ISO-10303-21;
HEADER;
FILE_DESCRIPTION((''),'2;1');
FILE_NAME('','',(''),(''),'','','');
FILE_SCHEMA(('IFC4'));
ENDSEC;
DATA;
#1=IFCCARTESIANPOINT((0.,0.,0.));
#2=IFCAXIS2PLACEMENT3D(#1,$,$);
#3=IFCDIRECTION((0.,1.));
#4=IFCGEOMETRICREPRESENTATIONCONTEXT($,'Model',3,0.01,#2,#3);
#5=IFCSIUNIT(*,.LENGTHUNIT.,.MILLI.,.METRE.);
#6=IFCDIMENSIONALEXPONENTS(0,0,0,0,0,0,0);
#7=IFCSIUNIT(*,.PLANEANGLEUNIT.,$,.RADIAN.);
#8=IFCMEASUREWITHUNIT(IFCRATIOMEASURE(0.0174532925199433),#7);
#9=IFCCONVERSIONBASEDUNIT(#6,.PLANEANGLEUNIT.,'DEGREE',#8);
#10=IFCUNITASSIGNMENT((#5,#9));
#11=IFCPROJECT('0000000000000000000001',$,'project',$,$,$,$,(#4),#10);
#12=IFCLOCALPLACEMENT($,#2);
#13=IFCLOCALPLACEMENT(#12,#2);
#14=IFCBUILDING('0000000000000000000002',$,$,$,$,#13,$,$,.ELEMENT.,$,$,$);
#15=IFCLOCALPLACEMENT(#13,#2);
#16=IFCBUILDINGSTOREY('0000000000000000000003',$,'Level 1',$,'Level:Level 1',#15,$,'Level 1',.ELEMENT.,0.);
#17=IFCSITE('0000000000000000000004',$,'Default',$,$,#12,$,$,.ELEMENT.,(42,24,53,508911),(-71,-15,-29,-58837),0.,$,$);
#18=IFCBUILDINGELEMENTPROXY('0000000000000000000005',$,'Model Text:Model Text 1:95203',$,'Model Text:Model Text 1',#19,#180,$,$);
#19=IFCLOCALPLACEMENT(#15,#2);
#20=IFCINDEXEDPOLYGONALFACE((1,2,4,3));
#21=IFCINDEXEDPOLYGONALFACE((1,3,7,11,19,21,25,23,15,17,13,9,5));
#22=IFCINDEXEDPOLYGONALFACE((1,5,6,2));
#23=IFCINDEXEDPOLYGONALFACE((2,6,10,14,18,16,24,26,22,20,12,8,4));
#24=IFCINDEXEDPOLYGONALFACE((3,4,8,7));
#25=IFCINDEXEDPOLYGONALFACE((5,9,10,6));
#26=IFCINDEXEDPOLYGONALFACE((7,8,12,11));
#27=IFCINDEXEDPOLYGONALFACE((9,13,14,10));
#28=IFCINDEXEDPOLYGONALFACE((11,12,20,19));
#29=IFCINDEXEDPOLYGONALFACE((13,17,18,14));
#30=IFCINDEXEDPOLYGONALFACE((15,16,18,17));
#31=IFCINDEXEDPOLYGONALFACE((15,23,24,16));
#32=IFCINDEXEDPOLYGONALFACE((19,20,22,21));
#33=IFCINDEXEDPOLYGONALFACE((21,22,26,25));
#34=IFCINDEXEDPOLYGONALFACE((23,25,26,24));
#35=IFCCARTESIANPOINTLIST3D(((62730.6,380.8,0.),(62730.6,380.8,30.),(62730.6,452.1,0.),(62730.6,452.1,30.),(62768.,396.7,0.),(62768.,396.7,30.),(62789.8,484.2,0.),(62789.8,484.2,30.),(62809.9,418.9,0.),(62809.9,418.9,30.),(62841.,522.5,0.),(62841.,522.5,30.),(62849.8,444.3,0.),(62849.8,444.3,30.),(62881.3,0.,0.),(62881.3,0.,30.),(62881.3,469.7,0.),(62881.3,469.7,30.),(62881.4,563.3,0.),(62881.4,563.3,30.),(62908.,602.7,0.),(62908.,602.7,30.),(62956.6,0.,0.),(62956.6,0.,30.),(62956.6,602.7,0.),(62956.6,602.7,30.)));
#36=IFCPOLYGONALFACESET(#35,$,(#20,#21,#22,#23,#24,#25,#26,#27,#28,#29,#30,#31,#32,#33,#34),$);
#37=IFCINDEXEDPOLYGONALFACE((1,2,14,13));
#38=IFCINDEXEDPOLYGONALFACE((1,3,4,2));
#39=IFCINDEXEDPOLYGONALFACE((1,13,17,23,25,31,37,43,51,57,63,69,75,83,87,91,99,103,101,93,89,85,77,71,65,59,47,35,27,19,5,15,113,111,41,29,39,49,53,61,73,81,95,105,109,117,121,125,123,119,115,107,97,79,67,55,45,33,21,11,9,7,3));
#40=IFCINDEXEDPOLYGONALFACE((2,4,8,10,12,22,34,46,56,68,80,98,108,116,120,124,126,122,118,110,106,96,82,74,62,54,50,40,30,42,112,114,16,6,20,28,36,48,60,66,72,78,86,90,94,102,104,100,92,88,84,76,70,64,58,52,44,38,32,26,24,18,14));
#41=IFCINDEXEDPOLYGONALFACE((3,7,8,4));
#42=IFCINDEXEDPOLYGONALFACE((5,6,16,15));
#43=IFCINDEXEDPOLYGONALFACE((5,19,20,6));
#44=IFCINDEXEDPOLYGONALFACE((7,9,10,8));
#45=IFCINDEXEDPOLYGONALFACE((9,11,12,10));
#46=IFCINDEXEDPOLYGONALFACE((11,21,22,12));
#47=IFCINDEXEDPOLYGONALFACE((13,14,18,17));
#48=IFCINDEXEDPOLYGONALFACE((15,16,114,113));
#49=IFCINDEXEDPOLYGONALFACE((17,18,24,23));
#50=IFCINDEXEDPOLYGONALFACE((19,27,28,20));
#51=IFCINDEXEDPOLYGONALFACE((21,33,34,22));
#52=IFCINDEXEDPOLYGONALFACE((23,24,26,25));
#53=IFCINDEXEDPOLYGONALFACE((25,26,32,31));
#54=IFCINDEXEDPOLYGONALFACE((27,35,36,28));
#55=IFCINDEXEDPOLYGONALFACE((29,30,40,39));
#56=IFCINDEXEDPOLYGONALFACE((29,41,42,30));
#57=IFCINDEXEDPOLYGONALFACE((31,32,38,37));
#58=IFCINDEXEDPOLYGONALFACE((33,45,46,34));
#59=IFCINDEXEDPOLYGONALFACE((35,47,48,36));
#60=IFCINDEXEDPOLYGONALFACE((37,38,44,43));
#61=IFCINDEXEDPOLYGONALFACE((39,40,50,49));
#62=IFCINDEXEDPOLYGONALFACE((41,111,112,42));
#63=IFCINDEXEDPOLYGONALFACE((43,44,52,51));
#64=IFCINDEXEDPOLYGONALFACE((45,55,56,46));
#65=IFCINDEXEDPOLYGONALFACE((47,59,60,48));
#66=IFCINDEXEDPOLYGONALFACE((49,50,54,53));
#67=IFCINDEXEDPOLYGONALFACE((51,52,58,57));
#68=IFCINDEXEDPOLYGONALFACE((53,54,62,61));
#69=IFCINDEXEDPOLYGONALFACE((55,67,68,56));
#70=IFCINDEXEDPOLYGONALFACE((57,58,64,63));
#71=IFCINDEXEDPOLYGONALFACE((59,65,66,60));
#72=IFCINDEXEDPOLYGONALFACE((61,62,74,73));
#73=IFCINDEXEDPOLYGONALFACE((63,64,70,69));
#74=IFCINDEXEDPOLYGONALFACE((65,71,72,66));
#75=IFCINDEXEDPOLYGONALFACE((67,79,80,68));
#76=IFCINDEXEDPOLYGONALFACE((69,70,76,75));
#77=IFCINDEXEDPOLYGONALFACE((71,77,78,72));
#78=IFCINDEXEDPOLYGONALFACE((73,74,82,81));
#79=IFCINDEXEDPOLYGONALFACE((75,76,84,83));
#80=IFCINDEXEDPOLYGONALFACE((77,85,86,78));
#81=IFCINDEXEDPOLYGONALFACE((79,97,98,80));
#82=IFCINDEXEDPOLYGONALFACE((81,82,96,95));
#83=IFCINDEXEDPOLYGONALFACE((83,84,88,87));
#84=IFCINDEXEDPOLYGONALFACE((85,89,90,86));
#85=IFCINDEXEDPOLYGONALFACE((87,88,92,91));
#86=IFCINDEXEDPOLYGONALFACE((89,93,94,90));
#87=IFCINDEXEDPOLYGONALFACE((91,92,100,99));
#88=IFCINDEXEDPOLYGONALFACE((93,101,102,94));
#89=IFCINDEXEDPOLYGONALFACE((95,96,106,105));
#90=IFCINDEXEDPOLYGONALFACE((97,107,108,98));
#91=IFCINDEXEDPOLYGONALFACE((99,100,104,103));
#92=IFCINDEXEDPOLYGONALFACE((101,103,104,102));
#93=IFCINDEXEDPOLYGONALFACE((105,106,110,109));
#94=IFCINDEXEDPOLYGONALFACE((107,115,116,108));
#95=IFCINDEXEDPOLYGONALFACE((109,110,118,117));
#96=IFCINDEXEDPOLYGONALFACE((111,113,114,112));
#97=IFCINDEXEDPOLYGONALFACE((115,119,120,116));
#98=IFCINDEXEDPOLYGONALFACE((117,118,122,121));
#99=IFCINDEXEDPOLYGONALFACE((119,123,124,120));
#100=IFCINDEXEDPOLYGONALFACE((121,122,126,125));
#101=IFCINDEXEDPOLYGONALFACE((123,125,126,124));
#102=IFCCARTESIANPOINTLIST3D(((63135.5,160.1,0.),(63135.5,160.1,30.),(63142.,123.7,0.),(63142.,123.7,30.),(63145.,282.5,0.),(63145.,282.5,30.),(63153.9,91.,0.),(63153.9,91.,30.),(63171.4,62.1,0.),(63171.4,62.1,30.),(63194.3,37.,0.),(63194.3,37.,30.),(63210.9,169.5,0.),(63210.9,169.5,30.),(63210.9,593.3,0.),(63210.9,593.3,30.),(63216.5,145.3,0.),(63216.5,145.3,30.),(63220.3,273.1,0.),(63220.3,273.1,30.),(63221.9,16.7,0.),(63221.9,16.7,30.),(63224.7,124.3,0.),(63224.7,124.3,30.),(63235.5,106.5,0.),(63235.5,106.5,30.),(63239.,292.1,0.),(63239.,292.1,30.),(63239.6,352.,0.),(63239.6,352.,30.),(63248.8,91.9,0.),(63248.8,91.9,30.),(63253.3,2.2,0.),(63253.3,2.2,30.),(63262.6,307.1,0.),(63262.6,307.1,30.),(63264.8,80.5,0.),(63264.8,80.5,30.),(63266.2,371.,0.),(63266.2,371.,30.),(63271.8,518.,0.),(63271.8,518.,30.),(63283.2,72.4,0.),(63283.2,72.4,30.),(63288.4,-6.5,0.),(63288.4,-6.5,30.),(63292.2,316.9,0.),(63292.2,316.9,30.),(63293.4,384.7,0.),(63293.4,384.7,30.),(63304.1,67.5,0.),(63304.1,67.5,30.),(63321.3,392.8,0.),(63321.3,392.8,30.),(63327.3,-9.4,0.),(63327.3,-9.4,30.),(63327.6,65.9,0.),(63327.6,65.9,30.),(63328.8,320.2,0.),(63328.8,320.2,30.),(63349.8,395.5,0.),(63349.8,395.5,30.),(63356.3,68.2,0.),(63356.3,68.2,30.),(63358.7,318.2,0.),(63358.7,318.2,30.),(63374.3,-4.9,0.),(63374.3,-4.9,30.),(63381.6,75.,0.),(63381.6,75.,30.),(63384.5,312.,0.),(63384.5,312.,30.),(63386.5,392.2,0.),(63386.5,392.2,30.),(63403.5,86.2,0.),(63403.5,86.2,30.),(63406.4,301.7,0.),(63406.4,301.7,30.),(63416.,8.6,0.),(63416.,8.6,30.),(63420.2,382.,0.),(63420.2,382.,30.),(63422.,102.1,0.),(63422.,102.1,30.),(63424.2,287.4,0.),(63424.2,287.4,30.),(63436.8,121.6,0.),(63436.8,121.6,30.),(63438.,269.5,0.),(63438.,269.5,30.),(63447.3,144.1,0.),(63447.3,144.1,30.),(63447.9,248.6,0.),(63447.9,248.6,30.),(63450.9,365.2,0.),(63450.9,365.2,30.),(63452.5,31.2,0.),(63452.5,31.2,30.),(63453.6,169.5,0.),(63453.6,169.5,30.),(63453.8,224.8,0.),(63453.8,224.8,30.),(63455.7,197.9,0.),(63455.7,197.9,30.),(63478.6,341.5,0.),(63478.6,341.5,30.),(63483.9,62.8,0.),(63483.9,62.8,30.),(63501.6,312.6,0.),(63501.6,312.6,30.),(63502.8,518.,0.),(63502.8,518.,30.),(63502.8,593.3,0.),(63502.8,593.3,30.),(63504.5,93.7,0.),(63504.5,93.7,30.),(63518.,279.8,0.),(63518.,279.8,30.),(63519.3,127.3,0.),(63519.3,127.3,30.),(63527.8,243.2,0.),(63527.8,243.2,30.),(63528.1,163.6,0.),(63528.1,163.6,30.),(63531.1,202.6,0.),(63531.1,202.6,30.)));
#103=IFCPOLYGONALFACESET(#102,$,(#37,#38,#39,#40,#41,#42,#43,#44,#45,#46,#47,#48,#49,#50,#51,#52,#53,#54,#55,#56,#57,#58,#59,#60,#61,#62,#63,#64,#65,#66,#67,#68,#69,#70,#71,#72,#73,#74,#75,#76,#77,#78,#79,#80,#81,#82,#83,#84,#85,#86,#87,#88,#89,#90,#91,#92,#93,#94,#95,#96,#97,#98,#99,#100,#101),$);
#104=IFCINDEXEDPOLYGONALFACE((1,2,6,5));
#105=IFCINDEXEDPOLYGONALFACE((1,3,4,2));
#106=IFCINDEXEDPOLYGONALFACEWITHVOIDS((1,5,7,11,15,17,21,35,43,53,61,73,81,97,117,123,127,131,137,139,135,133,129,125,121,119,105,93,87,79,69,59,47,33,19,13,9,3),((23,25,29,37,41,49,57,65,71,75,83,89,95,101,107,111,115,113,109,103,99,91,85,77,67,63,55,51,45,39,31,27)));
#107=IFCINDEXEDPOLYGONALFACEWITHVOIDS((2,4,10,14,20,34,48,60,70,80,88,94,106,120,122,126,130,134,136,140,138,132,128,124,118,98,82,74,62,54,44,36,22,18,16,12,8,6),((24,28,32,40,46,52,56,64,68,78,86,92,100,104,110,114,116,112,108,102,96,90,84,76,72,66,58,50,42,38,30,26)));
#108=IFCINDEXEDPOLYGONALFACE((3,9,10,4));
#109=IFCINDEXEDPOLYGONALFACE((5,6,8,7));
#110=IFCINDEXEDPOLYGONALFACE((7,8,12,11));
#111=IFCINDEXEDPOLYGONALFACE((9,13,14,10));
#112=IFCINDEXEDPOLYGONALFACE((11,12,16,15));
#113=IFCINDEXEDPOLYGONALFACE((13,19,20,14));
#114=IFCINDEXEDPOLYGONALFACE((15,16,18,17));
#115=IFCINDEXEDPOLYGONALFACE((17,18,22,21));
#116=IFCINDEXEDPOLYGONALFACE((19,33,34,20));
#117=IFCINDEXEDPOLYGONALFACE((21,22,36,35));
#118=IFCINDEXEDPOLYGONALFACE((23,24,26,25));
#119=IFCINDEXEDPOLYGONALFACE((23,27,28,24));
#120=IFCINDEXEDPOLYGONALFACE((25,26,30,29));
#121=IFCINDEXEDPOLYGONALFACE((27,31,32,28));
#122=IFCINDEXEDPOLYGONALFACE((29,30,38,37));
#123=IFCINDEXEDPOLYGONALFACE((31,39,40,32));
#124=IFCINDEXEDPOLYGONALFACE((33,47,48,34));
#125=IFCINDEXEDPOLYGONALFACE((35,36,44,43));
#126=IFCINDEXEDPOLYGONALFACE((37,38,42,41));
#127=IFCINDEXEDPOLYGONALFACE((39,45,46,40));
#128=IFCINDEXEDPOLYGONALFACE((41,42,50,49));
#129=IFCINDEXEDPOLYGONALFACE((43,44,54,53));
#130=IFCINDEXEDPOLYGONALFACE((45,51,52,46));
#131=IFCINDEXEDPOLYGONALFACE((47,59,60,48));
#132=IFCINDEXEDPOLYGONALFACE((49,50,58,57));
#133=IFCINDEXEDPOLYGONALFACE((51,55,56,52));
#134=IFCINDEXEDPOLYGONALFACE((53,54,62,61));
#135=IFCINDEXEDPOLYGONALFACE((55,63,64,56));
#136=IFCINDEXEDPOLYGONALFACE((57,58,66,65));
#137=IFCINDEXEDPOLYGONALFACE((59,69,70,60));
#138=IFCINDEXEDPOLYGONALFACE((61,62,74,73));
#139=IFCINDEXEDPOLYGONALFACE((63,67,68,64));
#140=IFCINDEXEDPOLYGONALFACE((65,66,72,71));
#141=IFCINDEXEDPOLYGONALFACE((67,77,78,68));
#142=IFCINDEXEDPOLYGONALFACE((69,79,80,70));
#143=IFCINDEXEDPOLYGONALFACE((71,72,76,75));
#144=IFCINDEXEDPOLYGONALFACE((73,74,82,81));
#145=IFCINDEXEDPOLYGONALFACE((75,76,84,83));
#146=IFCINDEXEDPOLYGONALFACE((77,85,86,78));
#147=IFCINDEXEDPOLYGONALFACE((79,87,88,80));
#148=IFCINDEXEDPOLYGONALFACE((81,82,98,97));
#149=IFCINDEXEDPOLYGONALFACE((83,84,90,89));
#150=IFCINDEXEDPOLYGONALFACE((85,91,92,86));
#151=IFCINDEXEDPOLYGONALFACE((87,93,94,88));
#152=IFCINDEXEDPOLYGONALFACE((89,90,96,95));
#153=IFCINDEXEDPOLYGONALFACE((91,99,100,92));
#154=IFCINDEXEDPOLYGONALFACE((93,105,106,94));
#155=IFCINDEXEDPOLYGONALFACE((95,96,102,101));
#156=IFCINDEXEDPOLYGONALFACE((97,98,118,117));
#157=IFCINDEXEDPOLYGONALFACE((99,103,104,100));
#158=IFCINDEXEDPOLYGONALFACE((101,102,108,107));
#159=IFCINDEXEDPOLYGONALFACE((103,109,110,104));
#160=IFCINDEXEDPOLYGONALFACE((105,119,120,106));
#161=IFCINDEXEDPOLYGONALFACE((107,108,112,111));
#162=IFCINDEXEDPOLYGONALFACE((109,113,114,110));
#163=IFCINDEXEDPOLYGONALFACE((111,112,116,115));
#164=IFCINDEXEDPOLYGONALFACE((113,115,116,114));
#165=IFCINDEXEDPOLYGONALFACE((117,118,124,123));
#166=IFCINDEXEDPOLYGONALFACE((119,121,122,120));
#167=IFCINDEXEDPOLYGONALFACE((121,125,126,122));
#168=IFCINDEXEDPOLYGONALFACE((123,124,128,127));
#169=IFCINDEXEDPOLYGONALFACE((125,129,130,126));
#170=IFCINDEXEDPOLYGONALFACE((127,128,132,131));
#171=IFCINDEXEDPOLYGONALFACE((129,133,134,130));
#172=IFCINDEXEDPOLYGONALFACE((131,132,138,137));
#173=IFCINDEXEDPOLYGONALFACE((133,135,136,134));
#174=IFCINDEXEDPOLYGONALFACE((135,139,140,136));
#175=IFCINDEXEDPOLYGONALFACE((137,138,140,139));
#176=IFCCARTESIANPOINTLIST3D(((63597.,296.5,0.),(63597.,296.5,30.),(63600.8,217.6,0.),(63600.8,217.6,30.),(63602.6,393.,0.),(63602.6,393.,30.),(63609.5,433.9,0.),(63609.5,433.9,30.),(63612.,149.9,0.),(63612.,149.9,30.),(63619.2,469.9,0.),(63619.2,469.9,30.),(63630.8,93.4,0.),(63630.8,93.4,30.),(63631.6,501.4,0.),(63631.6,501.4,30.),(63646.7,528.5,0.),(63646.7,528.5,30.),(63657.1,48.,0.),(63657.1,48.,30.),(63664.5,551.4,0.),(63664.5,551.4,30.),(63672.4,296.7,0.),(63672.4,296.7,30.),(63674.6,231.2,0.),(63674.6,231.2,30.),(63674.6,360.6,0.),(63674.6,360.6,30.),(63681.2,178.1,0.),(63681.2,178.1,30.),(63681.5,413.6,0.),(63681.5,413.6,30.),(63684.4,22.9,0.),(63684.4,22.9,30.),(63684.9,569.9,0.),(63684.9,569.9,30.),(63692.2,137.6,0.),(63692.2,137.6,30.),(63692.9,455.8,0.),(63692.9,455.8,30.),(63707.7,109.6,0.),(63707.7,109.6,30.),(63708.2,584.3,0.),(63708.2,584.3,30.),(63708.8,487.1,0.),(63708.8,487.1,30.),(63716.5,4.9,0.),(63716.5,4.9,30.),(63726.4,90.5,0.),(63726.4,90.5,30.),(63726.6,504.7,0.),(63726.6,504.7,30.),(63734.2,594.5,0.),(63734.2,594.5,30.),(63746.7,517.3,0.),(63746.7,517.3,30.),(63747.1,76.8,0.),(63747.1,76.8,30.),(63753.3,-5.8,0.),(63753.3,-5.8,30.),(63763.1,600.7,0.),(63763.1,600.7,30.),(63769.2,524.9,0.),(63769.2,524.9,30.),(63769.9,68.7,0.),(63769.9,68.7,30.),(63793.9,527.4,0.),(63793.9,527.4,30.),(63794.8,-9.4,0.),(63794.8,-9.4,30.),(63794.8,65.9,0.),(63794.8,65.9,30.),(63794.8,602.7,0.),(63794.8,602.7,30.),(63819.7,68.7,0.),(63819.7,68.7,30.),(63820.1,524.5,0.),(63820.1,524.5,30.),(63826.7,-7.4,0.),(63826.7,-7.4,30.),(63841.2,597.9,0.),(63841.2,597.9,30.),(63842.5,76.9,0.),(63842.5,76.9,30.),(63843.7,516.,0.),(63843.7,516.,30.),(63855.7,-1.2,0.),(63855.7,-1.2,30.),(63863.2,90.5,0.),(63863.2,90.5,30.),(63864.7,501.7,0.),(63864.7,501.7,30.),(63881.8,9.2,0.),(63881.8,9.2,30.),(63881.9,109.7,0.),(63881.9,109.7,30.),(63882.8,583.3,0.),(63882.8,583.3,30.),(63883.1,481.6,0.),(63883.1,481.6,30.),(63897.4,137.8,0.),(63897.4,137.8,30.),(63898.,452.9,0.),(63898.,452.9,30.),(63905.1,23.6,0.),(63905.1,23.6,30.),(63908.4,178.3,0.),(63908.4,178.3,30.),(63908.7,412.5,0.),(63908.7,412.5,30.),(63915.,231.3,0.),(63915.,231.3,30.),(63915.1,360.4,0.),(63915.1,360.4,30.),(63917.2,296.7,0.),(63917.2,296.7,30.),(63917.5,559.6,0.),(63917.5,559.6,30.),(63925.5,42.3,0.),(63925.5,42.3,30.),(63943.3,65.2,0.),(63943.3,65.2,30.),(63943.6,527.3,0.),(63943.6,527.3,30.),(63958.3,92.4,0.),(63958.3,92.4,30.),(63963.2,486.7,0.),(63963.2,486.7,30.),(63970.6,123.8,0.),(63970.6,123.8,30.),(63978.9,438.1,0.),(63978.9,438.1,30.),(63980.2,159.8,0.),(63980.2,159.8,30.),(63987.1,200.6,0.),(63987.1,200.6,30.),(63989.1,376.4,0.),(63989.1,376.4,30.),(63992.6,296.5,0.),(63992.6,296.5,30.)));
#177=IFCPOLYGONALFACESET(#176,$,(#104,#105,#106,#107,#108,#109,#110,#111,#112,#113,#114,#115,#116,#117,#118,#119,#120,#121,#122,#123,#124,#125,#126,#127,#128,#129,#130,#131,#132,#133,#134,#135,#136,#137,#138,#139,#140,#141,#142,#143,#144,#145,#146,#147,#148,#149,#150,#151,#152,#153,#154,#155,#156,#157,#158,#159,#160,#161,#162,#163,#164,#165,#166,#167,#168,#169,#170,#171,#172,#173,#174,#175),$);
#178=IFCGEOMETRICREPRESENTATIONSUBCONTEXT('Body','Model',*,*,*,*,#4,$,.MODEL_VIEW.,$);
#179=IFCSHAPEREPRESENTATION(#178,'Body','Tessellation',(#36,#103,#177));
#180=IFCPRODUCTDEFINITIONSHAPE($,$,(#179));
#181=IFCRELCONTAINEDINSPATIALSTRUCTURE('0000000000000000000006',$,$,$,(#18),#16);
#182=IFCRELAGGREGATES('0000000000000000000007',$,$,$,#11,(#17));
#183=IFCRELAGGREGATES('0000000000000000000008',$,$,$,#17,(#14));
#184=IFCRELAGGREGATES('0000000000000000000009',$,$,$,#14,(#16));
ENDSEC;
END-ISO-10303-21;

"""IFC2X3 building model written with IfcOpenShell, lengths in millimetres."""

from ifc_helpers import new_model, entity, si_unit, converted_unit, direction, frame, origin, place, context, subcontext, project, spatial, polyline, outline, extrude, element, save


model = new_model("IFC2X3")

# Units and contexts
model_context = context("Model", 3, precision=0.01, world=origin(), true_north=direction((0.0, 1.0)))
body_context = subcontext(model_context, "Body", "Model", "MODEL_VIEW")
ifc_project = project(units=[si_unit("LENGTHUNIT", "METRE", prefix="MILLI"), converted_unit("PLANEANGLEUNIT", "DEGREE", entity("IfcRatioMeasure", 0.0174532925199433), si_unit("PLANEANGLEUNIT", "RADIAN"), dimensions=[0, 0, 0, 0, 0, 0, 0])], contexts=[model_context])

# Site, building, storey
site_placement = place(None, origin())
site = spatial("IfcSite", under=ifc_project, at=site_placement, Name="Default", CompositionType="ELEMENT", RefLatitude=(42, 24, 53, 508911), RefLongitude=(-71, -15, -29, -58837), RefElevation=0.0)
building_placement = place(site_placement, origin())
building = spatial("IfcBuilding", under=site, at=building_placement, CompositionType="ELEMENT")
storey_placement = place(building_placement, origin())
storey = spatial("IfcBuildingStorey", under=building, at=storey_placement, Name="Level 1", ObjectType="Level:Level 1", LongName="Level 1", CompositionType="ELEMENT", Elevation=0.0)

# Building element proxy
proxy_1_placement = place(storey_placement, origin())
element("IfcBuildingElementProxy", 1, at=proxy_1_placement, inside=storey, Name="Model Text:Model Text 1:95203", ObjectType="Model Text:Model Text 1", context=body_context, shape_type="SweptSolid", body=[
    extrude(outline(polyline([(-410.6, -111.6), (192.1, -111.6), (192.1, -63.1), (152.7, -36.4), (111.9, 4.0), (73.6, 55.2), (41.4, 114.4), (-29.8, 114.4), (-13.9, 77.0), (8.3, 35.1), (33.7, -4.8), (59.1, -36.3), (-410.6, -36.3), (-410.6, -111.6)])), frame((62845.0, 410.6, 0.0), z_axis=(0.0, 0.0, 1.0), x_axis=(0.0, 1.0, 0.0)), (0.0, 0.0, 1.0), 30.0),
    extrude(outline(polyline([(12.1, -219.3), (49.1, -219.3), (83.4, -213.2), (114.8, -201.1), (143.5, -182.8), (168.3, -159.2), (188.1, -130.8), (202.8, -97.8), (212.4, -60.0), (216.1, -12.9), (210.0, 30.5), (194.1, 70.4), (168.4, 106.8), (141.6, 132.5), (111.1, 152.9), (76.9, 167.9), (39.0, 177.6), (-1.5, 181.4), (-39.3, 178.1), (-74.4, 167.6), (-106.9, 150.1), (-135.0, 126.9), (-157.0, 99.6), (-172.8, 68.1), (-182.5, 32.6), (-184.8, 4.0), (-181.6, -24.8), (-172.9, -54.0), (-158.8, -83.5), (-316.6, -22.9), (-276.5, 204.6), (-350.7, 217.7), (-401.4, -69.8), (-106.8, -188.8), (-84.5, -116.2), (-99.9, -94.5), (-110.6, -68.6), (-115.1, -37.8), (-112.0, -1.2), (-104.8, 27.9), (-94.2, 52.3), (-80.3, 72.0), (-63.1, 87.0), (-43.0, 97.5), (-20.8, 103.6), (3.8, 105.3), (30.5, 102.6), (58.1, 95.6), (82.1, 84.9), (102.4, 70.6), (119.1, 52.7), (131.4, 31.7), (138.7, 8.2), (141.0, -17.9), (138.2, -46.6), (132.6, -69.4), (124.1, -89.2), (112.9, -105.9), (99.0, -119.6), (82.3, -130.2), (62.9, -137.7), (40.8, -142.2), (15.9, -143.5), (12.1, -219.3)])), frame((63349.4, 210.2, 0.0), z_axis=(0.0, 0.0, 1.0), x_axis=(0.173842, -0.984774, 0.0)), (0.0, 0.0, 1.0), 30.0),
    extrude(outline(polyline([(-10.6, -198.7), (68.3, -198.7), (136.5, -190.7), (193.9, -174.7), (240.5, -150.6), (266.9, -124.4), (286.3, -93.2), (298.8, -57.0), (304.3, -15.7), (303.8, 16.2), (299.0, 45.5), (289.9, 72.1), (276.6, 96.0), (258.9, 117.3), (236.9, 136.2), (210.4, 152.5), (179.6, 166.3), (144.1, 177.6), (103.7, 186.3), (8.2, 196.4), (-71.8, 196.7), (-134.0, 189.4), (-183.3, 176.1), (-224.7, 158.4), (-258.2, 133.9), (-283.5, 100.3), (-300.1, 59.5), (-307.1, 13.4), (-306.6, -18.4), (-301.8, -47.5), (-292.8, -74.0), (-279.6, -97.9), (-262.0, -119.2), (-240.0, -138.1), (-213.6, -154.5), (-182.8, -168.4), (-147.3, -179.8), (-106.7, -188.6), (-10.6, -198.7)]), holes=[polyline([(-7.2, -123.5), (-71.0, -118.2), (-123.6, -108.8), (-165.2, -95.4), (-195.7, -78.0), (-212.4, -59.4), (-224.1, -38.7), (-230.6, -15.9), (-231.9, 8.9), (-227.8, 35.0), (-218.1, 58.1), (-202.8, 78.4), (-182.0, 95.8), (-152.6, 109.4), (-111.7, 118.1), (-59.4, 122.0), (4.4, 121.1), (69.6, 115.8), (122.2, 106.7), (162.2, 93.7), (189.5, 77.0), (207.7, 57.4), (220.4, 36.0), (227.5, 12.8), (229.1, -12.1), (225.2, -36.8), (215.9, -59.2), (201.3, -79.3), (181.4, -97.1), (152.6, -111.2), (111.6, -120.3), (58.3, -124.4), (-7.2, -123.5)])]), frame((63796.0, 295.3, 0.0), z_axis=(0.0, 0.0, 1.0), x_axis=(0.047515, -0.998871, 0.0)), (0.0, 0.0, 1.0), 30.0),
])

save(model, "model.ifc")
